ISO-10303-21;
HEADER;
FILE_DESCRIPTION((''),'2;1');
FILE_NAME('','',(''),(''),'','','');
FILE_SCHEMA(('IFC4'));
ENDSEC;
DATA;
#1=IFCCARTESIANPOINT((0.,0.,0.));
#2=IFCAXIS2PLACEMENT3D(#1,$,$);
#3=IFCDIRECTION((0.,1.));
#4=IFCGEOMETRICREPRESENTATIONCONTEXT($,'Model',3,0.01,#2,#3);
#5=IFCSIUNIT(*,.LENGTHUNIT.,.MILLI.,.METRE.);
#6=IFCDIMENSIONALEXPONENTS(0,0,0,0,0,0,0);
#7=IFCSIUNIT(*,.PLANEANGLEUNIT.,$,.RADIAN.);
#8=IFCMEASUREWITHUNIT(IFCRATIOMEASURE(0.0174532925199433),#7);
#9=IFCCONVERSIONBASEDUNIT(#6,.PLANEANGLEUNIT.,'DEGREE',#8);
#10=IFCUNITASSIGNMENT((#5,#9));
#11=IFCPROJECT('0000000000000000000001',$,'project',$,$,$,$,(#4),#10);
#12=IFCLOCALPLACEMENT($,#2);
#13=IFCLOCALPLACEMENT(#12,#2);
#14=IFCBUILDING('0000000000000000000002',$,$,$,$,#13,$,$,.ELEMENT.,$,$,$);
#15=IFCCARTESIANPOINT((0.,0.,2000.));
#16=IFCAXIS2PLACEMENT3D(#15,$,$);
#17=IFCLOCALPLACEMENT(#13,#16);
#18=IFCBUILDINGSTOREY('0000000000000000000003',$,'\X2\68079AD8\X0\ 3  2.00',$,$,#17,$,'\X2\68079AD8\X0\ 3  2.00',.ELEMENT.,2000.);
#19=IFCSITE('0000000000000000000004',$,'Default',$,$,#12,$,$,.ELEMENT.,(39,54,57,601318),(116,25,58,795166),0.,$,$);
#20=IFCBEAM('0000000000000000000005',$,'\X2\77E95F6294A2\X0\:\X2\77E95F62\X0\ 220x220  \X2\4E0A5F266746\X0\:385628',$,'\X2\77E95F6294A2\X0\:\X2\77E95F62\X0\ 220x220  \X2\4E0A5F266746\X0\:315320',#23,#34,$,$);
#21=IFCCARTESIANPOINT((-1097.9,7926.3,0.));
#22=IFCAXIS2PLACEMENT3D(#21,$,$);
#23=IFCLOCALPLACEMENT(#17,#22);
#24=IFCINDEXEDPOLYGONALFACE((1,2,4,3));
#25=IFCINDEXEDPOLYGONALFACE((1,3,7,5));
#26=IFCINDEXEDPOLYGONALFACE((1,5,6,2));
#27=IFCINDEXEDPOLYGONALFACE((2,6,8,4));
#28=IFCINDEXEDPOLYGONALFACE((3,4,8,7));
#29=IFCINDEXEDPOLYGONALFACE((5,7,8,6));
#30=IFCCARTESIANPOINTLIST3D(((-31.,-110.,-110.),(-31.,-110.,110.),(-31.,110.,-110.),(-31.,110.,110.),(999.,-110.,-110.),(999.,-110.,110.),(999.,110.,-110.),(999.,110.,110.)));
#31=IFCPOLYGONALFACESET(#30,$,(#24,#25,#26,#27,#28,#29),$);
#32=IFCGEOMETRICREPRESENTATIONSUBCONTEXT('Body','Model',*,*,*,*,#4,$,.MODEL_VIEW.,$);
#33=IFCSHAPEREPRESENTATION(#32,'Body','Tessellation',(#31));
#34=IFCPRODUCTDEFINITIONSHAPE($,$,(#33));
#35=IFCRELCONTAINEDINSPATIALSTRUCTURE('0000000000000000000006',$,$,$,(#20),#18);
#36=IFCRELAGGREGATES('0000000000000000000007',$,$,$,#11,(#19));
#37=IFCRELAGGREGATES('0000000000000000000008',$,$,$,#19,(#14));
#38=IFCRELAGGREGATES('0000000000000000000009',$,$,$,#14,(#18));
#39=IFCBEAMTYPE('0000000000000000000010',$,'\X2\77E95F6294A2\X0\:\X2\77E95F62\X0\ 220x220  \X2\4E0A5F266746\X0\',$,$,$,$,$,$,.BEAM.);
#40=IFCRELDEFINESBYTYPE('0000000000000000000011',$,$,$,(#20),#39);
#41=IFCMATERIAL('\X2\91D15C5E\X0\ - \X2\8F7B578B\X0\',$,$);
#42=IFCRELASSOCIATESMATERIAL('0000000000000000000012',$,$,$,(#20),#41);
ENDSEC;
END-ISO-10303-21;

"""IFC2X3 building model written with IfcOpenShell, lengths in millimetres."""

from ifc_helpers import new_model, entity, si_unit, converted_unit, direction, frame, frame_2d, origin, place, context, subcontext, project, spatial, rectangle, extrude, material, type_object, element, save


model = new_model("IFC2X3")

# Units and contexts
model_context = context("Model", 3, precision=0.01, world=origin(), true_north=direction((0.0, 1.0)))
body_context = subcontext(model_context, "Body", "Model", "MODEL_VIEW")
ifc_project = project(units=[si_unit("LENGTHUNIT", "METRE", prefix="MILLI"), converted_unit("PLANEANGLEUNIT", "DEGREE", entity("IfcRatioMeasure", 0.0174532925199433), si_unit("PLANEANGLEUNIT", "RADIAN"), dimensions=[0, 0, 0, 0, 0, 0, 0])], contexts=[model_context])

# Site, building, storey
site_placement = place(None, origin())
site = spatial("IfcSite", under=ifc_project, at=site_placement, Name="Default", CompositionType="ELEMENT", RefLatitude=(39, 54, 57, 601318), RefLongitude=(116, 25, 58, 795166), RefElevation=0.0)
building_placement = place(site_placement, origin())
building = spatial("IfcBuilding", under=site, at=building_placement, CompositionType="ELEMENT")
storey_placement = place(building_placement, frame((0.0, 0.0, 2000.0)))
storey = spatial("IfcBuildingStorey", under=building, at=storey_placement, Name="标高 3  2.00", LongName="标高 3  2.00", CompositionType="ELEMENT", Elevation=2000.0)

# Beam
ifc_material = material(Name="金属 - 轻型")
beam_type = type_object("IfcBeamType", Name="矩形钢:矩形 220x220  上弦杆", PredefinedType="BEAM")
beam_1_placement = place(storey_placement, frame((-1097.9, 7926.3, 0.0)))
element("IfcBeam", 1, at=beam_1_placement, inside=storey, type_object=beam_type, material=ifc_material, Name="矩形钢:矩形 220x220  上弦杆:385628", ObjectType="矩形钢:矩形 220x220  上弦杆:315320", context=body_context, shape_type="SweptSolid", body=[
    extrude(rectangle(XDim=220.0, YDim=220.0, at=frame_2d((0.0, 0.0), x_axis=(1.0, 0.0))), frame((-31.0, 0.0, 0.0), z_axis=(1.0, 0.0, 0.0), x_axis=(0.0, 0.0, -1.0)), (0.0, 0.0, 1.0), 1030.0),
])

save(model, "model.ifc")
